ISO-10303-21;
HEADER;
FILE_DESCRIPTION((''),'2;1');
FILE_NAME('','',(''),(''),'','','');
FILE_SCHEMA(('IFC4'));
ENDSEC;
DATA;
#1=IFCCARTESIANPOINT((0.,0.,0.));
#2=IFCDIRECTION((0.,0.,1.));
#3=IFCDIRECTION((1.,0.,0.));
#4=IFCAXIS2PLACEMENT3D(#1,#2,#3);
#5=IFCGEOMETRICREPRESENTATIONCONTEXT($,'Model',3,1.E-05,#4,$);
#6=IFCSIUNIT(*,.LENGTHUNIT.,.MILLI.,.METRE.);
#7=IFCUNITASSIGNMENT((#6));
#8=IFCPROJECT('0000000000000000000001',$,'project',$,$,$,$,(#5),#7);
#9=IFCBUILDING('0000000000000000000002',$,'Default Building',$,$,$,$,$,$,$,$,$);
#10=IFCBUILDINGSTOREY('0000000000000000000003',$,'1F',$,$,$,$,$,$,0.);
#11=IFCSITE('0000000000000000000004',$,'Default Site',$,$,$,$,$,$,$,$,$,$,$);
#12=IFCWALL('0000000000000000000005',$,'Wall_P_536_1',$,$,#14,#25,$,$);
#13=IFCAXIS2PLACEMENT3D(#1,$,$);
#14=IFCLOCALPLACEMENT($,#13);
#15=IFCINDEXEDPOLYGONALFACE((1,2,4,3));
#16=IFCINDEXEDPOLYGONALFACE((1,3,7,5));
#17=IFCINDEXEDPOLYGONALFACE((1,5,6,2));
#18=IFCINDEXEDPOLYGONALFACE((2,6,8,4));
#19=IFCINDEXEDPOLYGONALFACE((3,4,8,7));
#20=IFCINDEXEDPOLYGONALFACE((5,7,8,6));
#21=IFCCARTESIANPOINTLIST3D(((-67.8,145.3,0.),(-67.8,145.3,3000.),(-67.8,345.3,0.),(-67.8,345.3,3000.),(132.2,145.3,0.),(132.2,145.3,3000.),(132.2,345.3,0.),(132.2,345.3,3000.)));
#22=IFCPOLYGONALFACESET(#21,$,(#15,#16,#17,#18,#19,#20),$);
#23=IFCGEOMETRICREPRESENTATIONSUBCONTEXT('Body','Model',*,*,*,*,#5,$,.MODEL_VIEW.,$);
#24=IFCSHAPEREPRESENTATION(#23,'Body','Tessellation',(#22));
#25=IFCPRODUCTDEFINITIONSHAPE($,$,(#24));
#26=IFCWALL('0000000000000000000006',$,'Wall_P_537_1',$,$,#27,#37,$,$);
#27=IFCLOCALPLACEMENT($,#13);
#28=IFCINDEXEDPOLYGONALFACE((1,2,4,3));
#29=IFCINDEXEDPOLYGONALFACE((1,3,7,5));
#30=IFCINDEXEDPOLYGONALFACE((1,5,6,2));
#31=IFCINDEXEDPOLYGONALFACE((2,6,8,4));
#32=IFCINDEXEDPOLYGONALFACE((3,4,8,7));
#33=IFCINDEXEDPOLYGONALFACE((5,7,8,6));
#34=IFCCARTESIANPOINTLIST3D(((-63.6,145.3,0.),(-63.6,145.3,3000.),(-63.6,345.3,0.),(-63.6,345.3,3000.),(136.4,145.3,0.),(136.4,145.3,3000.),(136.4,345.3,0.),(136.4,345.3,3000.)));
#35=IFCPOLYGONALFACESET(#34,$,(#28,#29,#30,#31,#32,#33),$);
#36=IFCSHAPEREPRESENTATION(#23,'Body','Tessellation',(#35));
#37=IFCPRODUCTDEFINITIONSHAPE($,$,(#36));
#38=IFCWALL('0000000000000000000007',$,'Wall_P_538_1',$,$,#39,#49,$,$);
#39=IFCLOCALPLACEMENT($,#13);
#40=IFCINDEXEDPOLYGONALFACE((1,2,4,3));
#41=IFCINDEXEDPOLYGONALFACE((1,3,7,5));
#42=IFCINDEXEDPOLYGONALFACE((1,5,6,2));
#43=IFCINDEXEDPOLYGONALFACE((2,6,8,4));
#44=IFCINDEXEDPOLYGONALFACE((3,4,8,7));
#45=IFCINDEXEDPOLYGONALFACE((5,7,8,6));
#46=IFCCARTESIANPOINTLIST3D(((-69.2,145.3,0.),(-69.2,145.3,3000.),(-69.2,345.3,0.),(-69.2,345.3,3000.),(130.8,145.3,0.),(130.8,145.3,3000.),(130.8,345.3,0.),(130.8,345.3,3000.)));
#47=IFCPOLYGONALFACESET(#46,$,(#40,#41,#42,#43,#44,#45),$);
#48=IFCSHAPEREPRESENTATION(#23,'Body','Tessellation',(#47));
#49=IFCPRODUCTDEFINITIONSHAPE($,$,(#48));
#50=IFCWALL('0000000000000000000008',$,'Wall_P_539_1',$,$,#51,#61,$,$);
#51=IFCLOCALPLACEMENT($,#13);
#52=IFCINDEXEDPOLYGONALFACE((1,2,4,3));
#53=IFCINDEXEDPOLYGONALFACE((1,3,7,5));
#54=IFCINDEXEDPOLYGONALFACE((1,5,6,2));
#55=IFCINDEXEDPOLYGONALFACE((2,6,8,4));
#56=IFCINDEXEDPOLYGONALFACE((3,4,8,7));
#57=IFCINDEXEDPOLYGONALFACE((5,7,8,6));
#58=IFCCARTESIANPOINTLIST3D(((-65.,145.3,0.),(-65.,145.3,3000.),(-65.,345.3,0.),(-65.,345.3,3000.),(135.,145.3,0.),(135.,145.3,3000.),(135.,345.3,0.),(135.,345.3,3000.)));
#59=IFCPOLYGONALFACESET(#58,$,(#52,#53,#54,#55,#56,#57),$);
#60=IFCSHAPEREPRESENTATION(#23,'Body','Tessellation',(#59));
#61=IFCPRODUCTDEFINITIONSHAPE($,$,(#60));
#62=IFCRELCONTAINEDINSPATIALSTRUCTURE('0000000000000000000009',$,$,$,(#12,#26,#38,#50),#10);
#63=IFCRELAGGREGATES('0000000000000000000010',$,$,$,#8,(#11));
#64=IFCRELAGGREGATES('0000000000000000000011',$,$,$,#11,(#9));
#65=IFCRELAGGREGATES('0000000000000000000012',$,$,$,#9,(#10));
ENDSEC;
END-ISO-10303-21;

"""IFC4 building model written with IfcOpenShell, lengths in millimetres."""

from ifc_helpers import new_model, si_unit, frame, origin_with_axes, place, context, subcontext, project, spatial, indexed_curve, outline, extrude, element, save


model = new_model("IFC4")

# Units and contexts
model_context = context("Model", 3, precision=1e-05, world=origin_with_axes())
body_context = subcontext(model_context, "Body", "Model", "MODEL_VIEW")
ifc_project = project(units=[si_unit("LENGTHUNIT", "METRE", prefix="MILLI")], contexts=[model_context])

# Site, building, storey
site = spatial("IfcSite", under=ifc_project, Name="Default Site")
building = spatial("IfcBuilding", under=site, Name="Default Building")
storey = spatial("IfcBuildingStorey", under=building, Name="1F", Elevation=0.0)

# Walls
wall_1_placement = place(None, frame((132.2, 145.3, 0.0), z_axis=(0.0, 0.0, 1.0), x_axis=(0.0, 1.0, 0.0)))
element("IfcWall", 1, at=wall_1_placement, inside=storey, Name="Wall_P_536_1", context=body_context, shape_type="SweptSolid", body=[
    extrude(outline(indexed_curve([(0.0, 0.0), (0.0, 200.0), (200.0, 200.0), (200.0, 0.0), (0.0, 0.0)], self_intersect=False)), origin_with_axes(), (0.0, 0.0, 1.0), 3000.0),
])
wall_2_placement = place(None, frame((136.4, 145.3, 0.0), z_axis=(0.0, 0.0, 1.0), x_axis=(0.0, 1.0, 0.0)))
element("IfcWall", 2, at=wall_2_placement, inside=storey, Name="Wall_P_537_1", context=body_context, shape_type="SweptSolid", body=[
    extrude(outline(indexed_curve([(0.0, 0.0), (0.0, 200.0), (200.0, 200.0), (200.0, 0.0), (0.0, 0.0)], self_intersect=False)), origin_with_axes(), (0.0, 0.0, 1.0), 3000.0),
])
wall_3_placement = place(None, frame((130.8, 145.3, 0.0), z_axis=(0.0, 0.0, 1.0), x_axis=(0.0, 1.0, 0.0)))
element("IfcWall", 3, at=wall_3_placement, inside=storey, Name="Wall_P_538_1", context=body_context, shape_type="SweptSolid", body=[
    extrude(outline(indexed_curve([(0.0, 0.0), (0.0, 200.0), (200.0, 200.0), (200.0, 0.0), (0.0, 0.0)], self_intersect=False)), origin_with_axes(), (0.0, 0.0, 1.0), 3000.0),
])
wall_4_placement = place(None, frame((135.0, 145.3, 0.0), z_axis=(0.0, 0.0, 1.0), x_axis=(0.0, 1.0, 0.0)))
element("IfcWall", 4, at=wall_4_placement, inside=storey, Name="Wall_P_539_1", context=body_context, shape_type="SweptSolid", body=[
    extrude(outline(indexed_curve([(0.0, 0.0), (0.0, 200.0), (200.0, 200.0), (200.0, 0.0), (0.0, 0.0)], self_intersect=False)), origin_with_axes(), (0.0, 0.0, 1.0), 3000.0),
])

save(model, "model.ifc")
